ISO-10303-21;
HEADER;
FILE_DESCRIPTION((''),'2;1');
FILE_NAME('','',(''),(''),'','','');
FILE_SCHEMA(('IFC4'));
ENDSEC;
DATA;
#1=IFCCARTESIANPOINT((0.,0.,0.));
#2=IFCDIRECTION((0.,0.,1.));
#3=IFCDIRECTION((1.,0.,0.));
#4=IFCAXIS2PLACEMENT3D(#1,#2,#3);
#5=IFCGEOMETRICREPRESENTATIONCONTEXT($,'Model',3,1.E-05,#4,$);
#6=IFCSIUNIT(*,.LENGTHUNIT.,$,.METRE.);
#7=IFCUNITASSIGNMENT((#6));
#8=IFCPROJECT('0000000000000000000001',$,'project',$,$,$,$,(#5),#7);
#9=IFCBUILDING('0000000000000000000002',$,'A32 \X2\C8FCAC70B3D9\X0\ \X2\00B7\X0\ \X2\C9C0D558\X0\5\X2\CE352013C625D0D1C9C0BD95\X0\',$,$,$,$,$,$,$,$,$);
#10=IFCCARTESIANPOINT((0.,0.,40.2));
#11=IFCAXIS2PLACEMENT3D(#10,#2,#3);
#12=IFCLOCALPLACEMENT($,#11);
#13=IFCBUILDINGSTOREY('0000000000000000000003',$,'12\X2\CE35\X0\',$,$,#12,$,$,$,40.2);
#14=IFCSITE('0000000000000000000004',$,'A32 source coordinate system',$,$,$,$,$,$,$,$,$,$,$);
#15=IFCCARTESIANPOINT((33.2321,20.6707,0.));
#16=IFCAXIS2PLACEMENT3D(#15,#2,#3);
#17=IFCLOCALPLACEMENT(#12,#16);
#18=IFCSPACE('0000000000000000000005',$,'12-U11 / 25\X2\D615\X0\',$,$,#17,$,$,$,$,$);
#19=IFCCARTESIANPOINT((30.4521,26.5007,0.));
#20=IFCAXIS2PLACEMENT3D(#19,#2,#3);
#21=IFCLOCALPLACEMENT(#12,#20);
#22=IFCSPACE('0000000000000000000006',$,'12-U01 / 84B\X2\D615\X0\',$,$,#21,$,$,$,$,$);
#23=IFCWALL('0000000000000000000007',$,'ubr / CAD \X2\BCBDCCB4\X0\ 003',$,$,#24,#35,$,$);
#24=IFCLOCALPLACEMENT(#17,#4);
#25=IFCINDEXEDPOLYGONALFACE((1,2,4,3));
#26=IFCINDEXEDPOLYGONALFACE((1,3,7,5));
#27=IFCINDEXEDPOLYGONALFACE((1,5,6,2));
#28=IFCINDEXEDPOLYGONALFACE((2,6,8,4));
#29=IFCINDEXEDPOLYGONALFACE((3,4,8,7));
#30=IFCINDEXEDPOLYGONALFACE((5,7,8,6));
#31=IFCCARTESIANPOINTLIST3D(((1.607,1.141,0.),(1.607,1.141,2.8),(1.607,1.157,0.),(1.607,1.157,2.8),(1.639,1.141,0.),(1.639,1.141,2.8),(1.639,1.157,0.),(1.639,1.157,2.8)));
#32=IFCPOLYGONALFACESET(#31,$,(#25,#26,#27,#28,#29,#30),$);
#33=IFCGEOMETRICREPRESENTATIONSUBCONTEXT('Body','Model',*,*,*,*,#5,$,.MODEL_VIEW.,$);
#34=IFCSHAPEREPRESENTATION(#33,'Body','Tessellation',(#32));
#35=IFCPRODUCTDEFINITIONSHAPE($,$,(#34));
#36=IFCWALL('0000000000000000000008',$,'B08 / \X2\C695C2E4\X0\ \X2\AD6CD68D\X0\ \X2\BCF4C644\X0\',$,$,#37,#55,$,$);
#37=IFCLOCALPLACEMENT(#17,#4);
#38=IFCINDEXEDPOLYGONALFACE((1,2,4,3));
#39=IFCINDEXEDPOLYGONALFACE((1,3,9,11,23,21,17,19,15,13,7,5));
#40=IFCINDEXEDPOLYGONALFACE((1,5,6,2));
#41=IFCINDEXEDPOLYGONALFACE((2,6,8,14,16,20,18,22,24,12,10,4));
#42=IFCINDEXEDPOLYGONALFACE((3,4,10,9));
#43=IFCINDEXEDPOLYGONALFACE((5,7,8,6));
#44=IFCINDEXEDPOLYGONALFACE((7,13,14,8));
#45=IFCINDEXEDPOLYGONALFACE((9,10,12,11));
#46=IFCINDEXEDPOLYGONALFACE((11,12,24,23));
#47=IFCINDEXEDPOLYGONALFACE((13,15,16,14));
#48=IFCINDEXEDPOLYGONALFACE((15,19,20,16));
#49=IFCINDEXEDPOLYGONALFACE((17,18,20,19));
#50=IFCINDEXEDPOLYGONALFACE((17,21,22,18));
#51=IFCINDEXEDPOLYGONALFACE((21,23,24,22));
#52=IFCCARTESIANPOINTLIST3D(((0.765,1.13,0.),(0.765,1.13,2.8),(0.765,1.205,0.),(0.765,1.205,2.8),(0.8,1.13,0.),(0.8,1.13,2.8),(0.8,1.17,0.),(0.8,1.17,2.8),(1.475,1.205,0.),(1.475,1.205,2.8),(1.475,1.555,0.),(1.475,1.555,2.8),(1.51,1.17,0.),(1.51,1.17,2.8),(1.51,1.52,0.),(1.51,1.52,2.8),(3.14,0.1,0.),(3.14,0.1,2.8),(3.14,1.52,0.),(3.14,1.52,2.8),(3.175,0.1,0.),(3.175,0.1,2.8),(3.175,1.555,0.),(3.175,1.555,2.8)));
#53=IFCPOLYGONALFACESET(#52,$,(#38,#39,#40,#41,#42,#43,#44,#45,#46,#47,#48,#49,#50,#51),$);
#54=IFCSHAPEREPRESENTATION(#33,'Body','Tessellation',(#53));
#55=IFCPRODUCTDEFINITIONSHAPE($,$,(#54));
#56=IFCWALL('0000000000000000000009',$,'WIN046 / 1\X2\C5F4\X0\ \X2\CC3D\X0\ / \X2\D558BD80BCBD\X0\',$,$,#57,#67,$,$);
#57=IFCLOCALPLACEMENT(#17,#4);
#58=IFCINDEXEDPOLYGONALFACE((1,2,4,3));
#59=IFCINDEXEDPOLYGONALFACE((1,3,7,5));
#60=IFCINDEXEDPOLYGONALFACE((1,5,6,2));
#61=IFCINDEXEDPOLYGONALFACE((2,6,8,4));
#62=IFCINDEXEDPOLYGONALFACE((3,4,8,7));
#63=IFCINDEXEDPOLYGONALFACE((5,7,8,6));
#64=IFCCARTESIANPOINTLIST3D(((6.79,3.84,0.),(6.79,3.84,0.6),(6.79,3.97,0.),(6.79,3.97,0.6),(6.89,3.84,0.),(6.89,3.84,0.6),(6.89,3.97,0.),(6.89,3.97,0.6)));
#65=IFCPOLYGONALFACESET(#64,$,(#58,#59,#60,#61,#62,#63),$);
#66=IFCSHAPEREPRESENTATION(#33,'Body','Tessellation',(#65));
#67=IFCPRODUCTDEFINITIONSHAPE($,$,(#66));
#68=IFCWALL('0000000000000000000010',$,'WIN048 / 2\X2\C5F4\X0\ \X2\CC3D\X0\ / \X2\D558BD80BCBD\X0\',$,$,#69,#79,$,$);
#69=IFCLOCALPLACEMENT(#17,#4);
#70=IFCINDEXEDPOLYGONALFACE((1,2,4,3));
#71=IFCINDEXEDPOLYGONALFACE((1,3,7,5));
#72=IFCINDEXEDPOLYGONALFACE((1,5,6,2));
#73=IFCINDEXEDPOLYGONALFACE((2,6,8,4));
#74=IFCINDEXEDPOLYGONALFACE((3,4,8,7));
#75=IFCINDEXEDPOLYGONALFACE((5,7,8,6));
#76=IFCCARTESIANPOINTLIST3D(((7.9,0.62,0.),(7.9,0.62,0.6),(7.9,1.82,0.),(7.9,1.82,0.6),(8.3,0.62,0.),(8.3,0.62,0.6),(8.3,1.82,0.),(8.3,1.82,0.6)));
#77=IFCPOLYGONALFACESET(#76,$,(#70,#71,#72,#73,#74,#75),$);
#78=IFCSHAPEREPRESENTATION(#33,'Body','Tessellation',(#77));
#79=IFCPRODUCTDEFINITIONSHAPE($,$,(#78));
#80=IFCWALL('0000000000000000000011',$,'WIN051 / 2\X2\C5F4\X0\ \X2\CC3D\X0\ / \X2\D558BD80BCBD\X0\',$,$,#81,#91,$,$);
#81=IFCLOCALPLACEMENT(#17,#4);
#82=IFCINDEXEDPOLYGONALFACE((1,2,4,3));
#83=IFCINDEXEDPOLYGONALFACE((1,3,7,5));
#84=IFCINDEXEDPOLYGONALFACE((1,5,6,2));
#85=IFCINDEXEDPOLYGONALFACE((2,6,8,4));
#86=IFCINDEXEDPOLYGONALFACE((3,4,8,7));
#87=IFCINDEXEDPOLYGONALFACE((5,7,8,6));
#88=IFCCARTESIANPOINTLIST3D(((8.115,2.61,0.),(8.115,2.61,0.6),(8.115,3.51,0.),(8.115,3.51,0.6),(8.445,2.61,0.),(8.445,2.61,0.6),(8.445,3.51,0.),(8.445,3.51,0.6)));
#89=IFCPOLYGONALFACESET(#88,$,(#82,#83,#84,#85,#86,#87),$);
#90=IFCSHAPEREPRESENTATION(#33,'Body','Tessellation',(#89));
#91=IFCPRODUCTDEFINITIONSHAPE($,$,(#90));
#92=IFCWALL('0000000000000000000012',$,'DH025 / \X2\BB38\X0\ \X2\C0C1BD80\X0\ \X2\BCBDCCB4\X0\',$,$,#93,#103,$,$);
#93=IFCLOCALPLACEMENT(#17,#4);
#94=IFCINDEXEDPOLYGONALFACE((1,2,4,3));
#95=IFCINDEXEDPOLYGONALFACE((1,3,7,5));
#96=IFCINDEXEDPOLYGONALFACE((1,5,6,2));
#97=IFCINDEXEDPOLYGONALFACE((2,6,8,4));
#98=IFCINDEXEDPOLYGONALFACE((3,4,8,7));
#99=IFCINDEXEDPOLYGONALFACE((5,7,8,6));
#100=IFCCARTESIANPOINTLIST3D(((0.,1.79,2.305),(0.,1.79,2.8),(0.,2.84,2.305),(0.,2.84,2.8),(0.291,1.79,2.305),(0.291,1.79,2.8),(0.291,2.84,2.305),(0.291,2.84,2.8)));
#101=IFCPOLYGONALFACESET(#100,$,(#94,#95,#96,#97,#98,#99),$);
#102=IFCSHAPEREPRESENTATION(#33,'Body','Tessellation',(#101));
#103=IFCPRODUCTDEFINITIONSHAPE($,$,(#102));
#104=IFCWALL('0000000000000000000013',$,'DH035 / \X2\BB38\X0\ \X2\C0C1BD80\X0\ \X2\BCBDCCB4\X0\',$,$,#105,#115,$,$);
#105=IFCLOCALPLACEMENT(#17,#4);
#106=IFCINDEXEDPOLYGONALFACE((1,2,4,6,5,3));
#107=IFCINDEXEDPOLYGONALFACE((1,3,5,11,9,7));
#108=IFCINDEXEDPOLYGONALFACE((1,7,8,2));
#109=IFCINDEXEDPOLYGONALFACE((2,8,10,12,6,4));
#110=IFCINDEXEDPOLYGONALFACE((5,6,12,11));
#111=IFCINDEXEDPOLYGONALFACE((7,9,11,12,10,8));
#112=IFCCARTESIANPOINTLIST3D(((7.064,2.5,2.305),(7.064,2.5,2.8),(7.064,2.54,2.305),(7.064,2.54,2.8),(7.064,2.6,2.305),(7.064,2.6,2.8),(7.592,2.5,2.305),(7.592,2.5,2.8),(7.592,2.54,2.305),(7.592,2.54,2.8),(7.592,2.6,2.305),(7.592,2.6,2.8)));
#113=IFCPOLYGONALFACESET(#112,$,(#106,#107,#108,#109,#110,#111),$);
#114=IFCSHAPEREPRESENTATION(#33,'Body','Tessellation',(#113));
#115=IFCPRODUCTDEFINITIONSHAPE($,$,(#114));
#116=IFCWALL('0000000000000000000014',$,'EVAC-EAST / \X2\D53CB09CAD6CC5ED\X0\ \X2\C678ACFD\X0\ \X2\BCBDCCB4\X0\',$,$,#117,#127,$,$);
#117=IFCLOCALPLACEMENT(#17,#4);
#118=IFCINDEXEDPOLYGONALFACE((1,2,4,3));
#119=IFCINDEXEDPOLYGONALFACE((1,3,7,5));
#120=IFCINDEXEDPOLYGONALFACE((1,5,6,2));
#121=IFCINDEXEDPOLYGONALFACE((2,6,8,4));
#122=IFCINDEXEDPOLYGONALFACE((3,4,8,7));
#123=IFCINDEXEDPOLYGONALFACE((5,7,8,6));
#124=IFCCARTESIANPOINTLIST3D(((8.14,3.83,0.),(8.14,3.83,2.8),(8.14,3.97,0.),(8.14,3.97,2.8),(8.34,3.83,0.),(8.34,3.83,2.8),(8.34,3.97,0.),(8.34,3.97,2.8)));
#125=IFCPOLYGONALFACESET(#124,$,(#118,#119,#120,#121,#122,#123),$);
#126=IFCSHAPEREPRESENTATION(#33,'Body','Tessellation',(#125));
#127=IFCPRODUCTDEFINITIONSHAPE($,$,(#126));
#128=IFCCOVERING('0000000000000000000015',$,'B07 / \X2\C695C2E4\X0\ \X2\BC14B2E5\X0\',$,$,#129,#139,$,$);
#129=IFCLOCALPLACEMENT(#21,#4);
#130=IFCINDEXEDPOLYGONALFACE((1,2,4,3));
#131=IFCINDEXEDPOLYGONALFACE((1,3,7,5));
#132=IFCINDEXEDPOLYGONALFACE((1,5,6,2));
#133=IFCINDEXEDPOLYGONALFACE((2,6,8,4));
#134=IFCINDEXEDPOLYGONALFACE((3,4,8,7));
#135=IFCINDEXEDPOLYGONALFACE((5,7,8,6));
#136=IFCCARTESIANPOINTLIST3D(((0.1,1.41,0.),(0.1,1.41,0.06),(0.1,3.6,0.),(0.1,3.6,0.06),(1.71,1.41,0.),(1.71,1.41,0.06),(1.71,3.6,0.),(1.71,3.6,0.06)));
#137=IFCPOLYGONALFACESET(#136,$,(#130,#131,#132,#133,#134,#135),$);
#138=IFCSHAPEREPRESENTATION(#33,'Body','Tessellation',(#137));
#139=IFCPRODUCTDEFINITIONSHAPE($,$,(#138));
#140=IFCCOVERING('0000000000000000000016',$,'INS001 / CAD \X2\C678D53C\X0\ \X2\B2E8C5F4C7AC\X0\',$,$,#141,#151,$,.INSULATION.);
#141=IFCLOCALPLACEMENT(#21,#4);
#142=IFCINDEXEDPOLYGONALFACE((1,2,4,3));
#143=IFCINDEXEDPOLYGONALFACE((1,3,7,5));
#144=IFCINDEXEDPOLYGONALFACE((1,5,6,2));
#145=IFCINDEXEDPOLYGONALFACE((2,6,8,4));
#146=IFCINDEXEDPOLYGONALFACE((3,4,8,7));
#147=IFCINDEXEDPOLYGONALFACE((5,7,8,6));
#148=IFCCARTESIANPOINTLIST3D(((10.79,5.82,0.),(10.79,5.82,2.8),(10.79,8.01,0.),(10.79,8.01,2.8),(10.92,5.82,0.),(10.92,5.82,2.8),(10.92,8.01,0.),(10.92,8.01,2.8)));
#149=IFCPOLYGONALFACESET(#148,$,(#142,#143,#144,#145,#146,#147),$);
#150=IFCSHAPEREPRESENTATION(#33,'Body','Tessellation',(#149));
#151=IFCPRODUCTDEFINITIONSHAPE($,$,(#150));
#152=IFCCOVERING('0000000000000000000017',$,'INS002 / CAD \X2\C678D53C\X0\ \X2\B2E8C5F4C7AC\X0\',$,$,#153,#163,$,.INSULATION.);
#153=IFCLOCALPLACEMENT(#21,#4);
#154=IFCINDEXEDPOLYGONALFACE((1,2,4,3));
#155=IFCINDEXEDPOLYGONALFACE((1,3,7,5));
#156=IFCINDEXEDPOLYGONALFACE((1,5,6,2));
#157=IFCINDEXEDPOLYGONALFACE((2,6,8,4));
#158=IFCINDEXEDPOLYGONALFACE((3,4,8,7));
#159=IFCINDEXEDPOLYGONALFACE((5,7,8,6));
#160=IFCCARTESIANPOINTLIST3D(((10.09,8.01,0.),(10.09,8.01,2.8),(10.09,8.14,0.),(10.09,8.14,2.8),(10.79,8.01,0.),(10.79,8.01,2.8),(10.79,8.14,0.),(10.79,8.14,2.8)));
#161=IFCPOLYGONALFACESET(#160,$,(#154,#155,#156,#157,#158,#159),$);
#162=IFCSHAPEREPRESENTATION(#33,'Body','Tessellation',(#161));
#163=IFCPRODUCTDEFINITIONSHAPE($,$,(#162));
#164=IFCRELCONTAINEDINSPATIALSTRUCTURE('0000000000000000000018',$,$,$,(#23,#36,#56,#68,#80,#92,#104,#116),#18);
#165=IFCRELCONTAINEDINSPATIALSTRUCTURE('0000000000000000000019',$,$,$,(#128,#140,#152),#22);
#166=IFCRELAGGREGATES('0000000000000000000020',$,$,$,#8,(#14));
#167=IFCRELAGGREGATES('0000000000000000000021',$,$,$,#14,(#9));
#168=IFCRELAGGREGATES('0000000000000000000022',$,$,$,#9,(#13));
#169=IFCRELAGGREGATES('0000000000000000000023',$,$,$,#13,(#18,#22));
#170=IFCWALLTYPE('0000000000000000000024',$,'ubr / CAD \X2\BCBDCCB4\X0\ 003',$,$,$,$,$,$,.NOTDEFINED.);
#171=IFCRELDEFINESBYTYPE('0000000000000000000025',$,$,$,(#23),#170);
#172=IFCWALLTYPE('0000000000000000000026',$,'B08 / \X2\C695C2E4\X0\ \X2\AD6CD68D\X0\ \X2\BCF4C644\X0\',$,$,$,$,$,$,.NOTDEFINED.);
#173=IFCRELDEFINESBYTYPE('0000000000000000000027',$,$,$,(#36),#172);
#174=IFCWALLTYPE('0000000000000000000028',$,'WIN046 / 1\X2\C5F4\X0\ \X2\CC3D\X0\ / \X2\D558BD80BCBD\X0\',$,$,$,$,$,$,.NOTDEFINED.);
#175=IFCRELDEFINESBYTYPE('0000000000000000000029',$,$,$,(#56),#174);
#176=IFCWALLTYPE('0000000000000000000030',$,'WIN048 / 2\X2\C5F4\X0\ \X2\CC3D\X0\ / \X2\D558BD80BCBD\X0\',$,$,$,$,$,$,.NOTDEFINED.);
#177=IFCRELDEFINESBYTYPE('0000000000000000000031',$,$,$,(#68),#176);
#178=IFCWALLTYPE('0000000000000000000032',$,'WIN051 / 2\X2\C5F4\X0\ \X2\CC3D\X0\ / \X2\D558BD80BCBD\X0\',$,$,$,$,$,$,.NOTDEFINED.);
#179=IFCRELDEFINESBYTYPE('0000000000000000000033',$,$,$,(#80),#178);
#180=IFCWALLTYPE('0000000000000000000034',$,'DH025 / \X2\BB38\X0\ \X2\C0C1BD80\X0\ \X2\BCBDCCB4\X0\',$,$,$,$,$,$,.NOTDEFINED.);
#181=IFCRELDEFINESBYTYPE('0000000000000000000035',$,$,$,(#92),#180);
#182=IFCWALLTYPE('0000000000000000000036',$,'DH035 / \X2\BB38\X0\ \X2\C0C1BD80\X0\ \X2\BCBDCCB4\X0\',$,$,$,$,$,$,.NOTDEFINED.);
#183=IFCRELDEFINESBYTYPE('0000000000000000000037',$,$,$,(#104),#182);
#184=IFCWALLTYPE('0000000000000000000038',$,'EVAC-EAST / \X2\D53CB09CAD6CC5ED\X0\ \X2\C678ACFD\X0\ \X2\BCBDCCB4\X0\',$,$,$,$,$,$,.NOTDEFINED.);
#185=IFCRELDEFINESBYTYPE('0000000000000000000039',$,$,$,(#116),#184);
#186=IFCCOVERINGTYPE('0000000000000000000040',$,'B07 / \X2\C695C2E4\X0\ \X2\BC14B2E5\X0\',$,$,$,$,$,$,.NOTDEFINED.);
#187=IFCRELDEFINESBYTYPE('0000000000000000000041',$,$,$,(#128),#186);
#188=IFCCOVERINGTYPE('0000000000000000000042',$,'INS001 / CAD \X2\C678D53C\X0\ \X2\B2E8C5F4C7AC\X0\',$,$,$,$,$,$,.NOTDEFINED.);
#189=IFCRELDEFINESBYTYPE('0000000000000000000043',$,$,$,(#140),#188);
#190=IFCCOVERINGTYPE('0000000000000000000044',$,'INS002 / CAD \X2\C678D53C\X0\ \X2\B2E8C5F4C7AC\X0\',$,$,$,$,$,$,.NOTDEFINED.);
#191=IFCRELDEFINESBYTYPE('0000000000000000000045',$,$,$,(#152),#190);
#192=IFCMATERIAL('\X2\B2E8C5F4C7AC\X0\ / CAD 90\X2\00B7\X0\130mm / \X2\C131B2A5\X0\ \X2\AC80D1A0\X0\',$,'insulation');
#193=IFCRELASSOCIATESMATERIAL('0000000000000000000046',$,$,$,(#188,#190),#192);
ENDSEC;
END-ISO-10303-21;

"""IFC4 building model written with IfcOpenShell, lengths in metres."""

from ifc_helpers import new_model, si_unit, frame, origin, origin_with_axes, place, context, subcontext, project, spatial, polyline, outline, extrude, source, transform, mapped, material, type_object, type_shapes, element, save


model = new_model("IFC4")

# Units and contexts
model_context = context("Model", 3, precision=1e-05, world=origin_with_axes())
body_context = subcontext(model_context, "Body", "Model", "MODEL_VIEW")
ifc_project = project(units=[si_unit("LENGTHUNIT", "METRE")], contexts=[model_context])

# Site, building, storey, space
site = spatial("IfcSite", under=ifc_project, Name="A32 source coordinate system")
building = spatial("IfcBuilding", under=site, Name="A32 주거동 · 지하5층–옥탑지붕")
storey_placement = place(None, frame((0.0, 0.0, 40.2), z_axis=(0.0, 0.0, 1.0), x_axis=(1.0, 0.0, 0.0)))
storey = spatial("IfcBuildingStorey", under=building, at=storey_placement, Name="12층", Elevation=40.2)
space_1_placement = place(storey_placement, frame((33.2321, 20.6707, 0.0), z_axis=(0.0, 0.0, 1.0), x_axis=(1.0, 0.0, 0.0)))
space_1 = spatial("IfcSpace", under=storey, at=space_1_placement, Name="12-U11 / 25형")

# Walls
wall_type_1 = type_object("IfcWallType", Name="ubr / CAD 벽체 003", PredefinedType="NOTDEFINED")
shared_shape_1 = source(origin(), body_context, "Body", "SweptSolid", [
    extrude(outline(polyline([(1.639, 1.157), (1.639, 1.141), (1.607, 1.141), (1.607, 1.157), (1.639, 1.157)])), origin(), (0.0, 0.0, 1.0), 2.8),
])
type_shapes(wall_type_1, [shared_shape_1])
wall_1_placement = place(space_1_placement, origin_with_axes())
element("IfcWall", 1, at=wall_1_placement, inside=space_1, type_object=wall_type_1, Name="ubr / CAD 벽체 003", context=body_context, shape_type="MappedRepresentation", body=[
    mapped(shared_shape_1, transform((0.0, 0.0, 0.0), scale=1.0)),
])
wall_type_2 = type_object("IfcWallType", Name="B08 / 욕실 구획 보완", PredefinedType="NOTDEFINED")
shared_shape_2 = source(origin(), body_context, "Body", "SweptSolid", [
    extrude(outline(polyline([(0.765, 1.205), (1.475, 1.205), (1.475, 1.555), (3.175, 1.555), (3.175, 0.1), (3.14, 0.1), (3.14, 1.52), (1.51, 1.52), (1.51, 1.17), (0.8, 1.17), (0.8, 1.13), (0.765, 1.13), (0.765, 1.205)])), origin(), (0.0, 0.0, 1.0), 2.8),
])
type_shapes(wall_type_2, [shared_shape_2])
wall_2_placement = place(space_1_placement, origin_with_axes())
element("IfcWall", 2, at=wall_2_placement, inside=space_1, type_object=wall_type_2, Name="B08 / 욕실 구획 보완", context=body_context, shape_type="MappedRepresentation", body=[
    mapped(shared_shape_2, transform((0.0, 0.0, 0.0), scale=1.0)),
])
wall_type_3 = type_object("IfcWallType", Name="WIN046 / 1열 창 / 하부벽", PredefinedType="NOTDEFINED")
shared_shape_3 = source(origin(), body_context, "Body", "SweptSolid", [
    extrude(outline(polyline([(6.89, 3.84), (6.79, 3.84), (6.79, 3.97), (6.89, 3.97), (6.89, 3.84)])), origin(), (0.0, 0.0, 1.0), 0.6),
])
type_shapes(wall_type_3, [shared_shape_3])
wall_3_placement = place(space_1_placement, origin_with_axes())
element("IfcWall", 3, at=wall_3_placement, inside=space_1, type_object=wall_type_3, Name="WIN046 / 1열 창 / 하부벽", context=body_context, shape_type="MappedRepresentation", body=[
    mapped(shared_shape_3, transform((0.0, 0.0, 0.0), scale=1.0)),
])
wall_type_4 = type_object("IfcWallType", Name="WIN048 / 2열 창 / 하부벽", PredefinedType="NOTDEFINED")
shared_shape_4 = source(origin(), body_context, "Body", "SweptSolid", [
    extrude(outline(polyline([(8.3, 0.62), (7.9, 0.62), (7.9, 1.82), (8.3, 1.82), (8.3, 0.62)])), origin(), (0.0, 0.0, 1.0), 0.6),
])
type_shapes(wall_type_4, [shared_shape_4])
wall_4_placement = place(space_1_placement, origin_with_axes())
element("IfcWall", 4, at=wall_4_placement, inside=space_1, type_object=wall_type_4, Name="WIN048 / 2열 창 / 하부벽", context=body_context, shape_type="MappedRepresentation", body=[
    mapped(shared_shape_4, transform((0.0, 0.0, 0.0), scale=1.0)),
])
wall_type_5 = type_object("IfcWallType", Name="WIN051 / 2열 창 / 하부벽", PredefinedType="NOTDEFINED")
shared_shape_5 = source(origin(), body_context, "Body", "SweptSolid", [
    extrude(outline(polyline([(8.445, 2.61), (8.115, 2.61), (8.115, 3.51), (8.445, 3.51), (8.445, 2.61)])), origin(), (0.0, 0.0, 1.0), 0.6),
])
type_shapes(wall_type_5, [shared_shape_5])
wall_5_placement = place(space_1_placement, origin_with_axes())
element("IfcWall", 5, at=wall_5_placement, inside=space_1, type_object=wall_type_5, Name="WIN051 / 2열 창 / 하부벽", context=body_context, shape_type="MappedRepresentation", body=[
    mapped(shared_shape_5, transform((0.0, 0.0, 0.0), scale=1.0)),
])
wall_type_6 = type_object("IfcWallType", Name="DH025 / 문 상부 벽체", PredefinedType="NOTDEFINED")
shared_shape_6 = source(origin(), body_context, "Body", "SweptSolid", [
    extrude(outline(polyline([(0.0, 1.79), (0.0, 2.84), (0.291, 2.84), (0.291, 1.79), (0.0, 1.79)])), frame((0.0, 0.0, 2.305)), (0.0, 0.0, 1.0), 0.495),
])
type_shapes(wall_type_6, [shared_shape_6])
wall_6_placement = place(space_1_placement, origin_with_axes())
element("IfcWall", 6, at=wall_6_placement, inside=space_1, type_object=wall_type_6, Name="DH025 / 문 상부 벽체", context=body_context, shape_type="MappedRepresentation", body=[
    mapped(shared_shape_6, transform((0.0, 0.0, 0.0), scale=1.0)),
])
wall_type_7 = type_object("IfcWallType", Name="DH035 / 문 상부 벽체", PredefinedType="NOTDEFINED")
shared_shape_7 = source(origin(), body_context, "Body", "SweptSolid", [
    extrude(outline(polyline([(7.592, 2.6), (7.592, 2.54), (7.592, 2.5), (7.064, 2.5), (7.064, 2.54), (7.064, 2.6), (7.592, 2.6)])), frame((0.0, 0.0, 2.305)), (0.0, 0.0, 1.0), 0.495),
])
type_shapes(wall_type_7, [shared_shape_7])
wall_7_placement = place(space_1_placement, origin_with_axes())
element("IfcWall", 7, at=wall_7_placement, inside=space_1, type_object=wall_type_7, Name="DH035 / 문 상부 벽체", context=body_context, shape_type="MappedRepresentation", body=[
    mapped(shared_shape_7, transform((0.0, 0.0, 0.0), scale=1.0)),
])
wall_type_8 = type_object("IfcWallType", Name="EVAC-EAST / 피난구역 외곽 벽체", PredefinedType="NOTDEFINED")
shared_shape_8 = source(origin(), body_context, "Body", "SweptSolid", [
    extrude(outline(polyline([(8.34, 3.83), (8.14, 3.83), (8.14, 3.97), (8.34, 3.97), (8.34, 3.83)])), origin(), (0.0, 0.0, 1.0), 2.8),
])
type_shapes(wall_type_8, [shared_shape_8])
wall_8_placement = place(space_1_placement, origin_with_axes())
element("IfcWall", 8, at=wall_8_placement, inside=space_1, type_object=wall_type_8, Name="EVAC-EAST / 피난구역 외곽 벽체", context=body_context, shape_type="MappedRepresentation", body=[
    mapped(shared_shape_8, transform((0.0, 0.0, 0.0), scale=1.0)),
])

# Shared definitions
space_2_placement = place(storey_placement, frame((30.4521, 26.5007, 0.0), z_axis=(0.0, 0.0, 1.0), x_axis=(1.0, 0.0, 0.0)))
space_2 = spatial("IfcSpace", under=storey, at=space_2_placement, Name="12-U01 / 84B형")

# Coverings
covering_type_1 = type_object("IfcCoveringType", Name="B07 / 욕실 바닥", PredefinedType="NOTDEFINED")
shared_shape_9 = source(origin(), body_context, "Body", "SweptSolid", [
    extrude(outline(polyline([(1.71, 1.41), (0.1, 1.41), (0.1, 3.6), (1.71, 3.6), (1.71, 1.41)])), origin(), (0.0, 0.0, 1.0), 0.06),
])
type_shapes(covering_type_1, [shared_shape_9])
covering_1_placement = place(space_2_placement, origin_with_axes())
element("IfcCovering", 9, at=covering_1_placement, inside=space_2, type_object=covering_type_1, Name="B07 / 욕실 바닥", context=body_context, shape_type="MappedRepresentation", body=[
    mapped(shared_shape_9, transform((0.0, 0.0, 0.0), scale=1.0)),
])
ifc_material = material(Name="단열재 / CAD 90·130mm / 성능 검토", Category="insulation")
covering_type_2 = type_object("IfcCoveringType", Name="INS001 / CAD 외피 단열재", PredefinedType="NOTDEFINED", material=ifc_material)
shared_shape_10 = source(origin(), body_context, "Body", "SweptSolid", [
    extrude(outline(polyline([(10.79, 5.82), (10.79, 8.01), (10.92, 8.01), (10.92, 5.82), (10.79, 5.82)])), origin(), (0.0, 0.0, 1.0), 2.8),
])
type_shapes(covering_type_2, [shared_shape_10])
covering_2_placement = place(space_2_placement, origin_with_axes())
element("IfcCovering", 10, at=covering_2_placement, inside=space_2, type_object=covering_type_2, Name="INS001 / CAD 외피 단열재", PredefinedType="INSULATION", context=body_context, shape_type="MappedRepresentation", body=[
    mapped(shared_shape_10, transform((0.0, 0.0, 0.0), scale=1.0)),
])
covering_type_3 = type_object("IfcCoveringType", Name="INS002 / CAD 외피 단열재", PredefinedType="NOTDEFINED", material=ifc_material)
shared_shape_11 = source(origin(), body_context, "Body", "SweptSolid", [
    extrude(outline(polyline([(10.79, 8.01), (10.09, 8.01), (10.09, 8.14), (10.79, 8.14), (10.79, 8.01)])), origin(), (0.0, 0.0, 1.0), 2.8),
])
type_shapes(covering_type_3, [shared_shape_11])
covering_3_placement = place(space_2_placement, origin_with_axes())
element("IfcCovering", 11, at=covering_3_placement, inside=space_2, type_object=covering_type_3, Name="INS002 / CAD 외피 단열재", PredefinedType="INSULATION", context=body_context, shape_type="MappedRepresentation", body=[
    mapped(shared_shape_11, transform((0.0, 0.0, 0.0), scale=1.0)),
])

save(model, "model.ifc")
